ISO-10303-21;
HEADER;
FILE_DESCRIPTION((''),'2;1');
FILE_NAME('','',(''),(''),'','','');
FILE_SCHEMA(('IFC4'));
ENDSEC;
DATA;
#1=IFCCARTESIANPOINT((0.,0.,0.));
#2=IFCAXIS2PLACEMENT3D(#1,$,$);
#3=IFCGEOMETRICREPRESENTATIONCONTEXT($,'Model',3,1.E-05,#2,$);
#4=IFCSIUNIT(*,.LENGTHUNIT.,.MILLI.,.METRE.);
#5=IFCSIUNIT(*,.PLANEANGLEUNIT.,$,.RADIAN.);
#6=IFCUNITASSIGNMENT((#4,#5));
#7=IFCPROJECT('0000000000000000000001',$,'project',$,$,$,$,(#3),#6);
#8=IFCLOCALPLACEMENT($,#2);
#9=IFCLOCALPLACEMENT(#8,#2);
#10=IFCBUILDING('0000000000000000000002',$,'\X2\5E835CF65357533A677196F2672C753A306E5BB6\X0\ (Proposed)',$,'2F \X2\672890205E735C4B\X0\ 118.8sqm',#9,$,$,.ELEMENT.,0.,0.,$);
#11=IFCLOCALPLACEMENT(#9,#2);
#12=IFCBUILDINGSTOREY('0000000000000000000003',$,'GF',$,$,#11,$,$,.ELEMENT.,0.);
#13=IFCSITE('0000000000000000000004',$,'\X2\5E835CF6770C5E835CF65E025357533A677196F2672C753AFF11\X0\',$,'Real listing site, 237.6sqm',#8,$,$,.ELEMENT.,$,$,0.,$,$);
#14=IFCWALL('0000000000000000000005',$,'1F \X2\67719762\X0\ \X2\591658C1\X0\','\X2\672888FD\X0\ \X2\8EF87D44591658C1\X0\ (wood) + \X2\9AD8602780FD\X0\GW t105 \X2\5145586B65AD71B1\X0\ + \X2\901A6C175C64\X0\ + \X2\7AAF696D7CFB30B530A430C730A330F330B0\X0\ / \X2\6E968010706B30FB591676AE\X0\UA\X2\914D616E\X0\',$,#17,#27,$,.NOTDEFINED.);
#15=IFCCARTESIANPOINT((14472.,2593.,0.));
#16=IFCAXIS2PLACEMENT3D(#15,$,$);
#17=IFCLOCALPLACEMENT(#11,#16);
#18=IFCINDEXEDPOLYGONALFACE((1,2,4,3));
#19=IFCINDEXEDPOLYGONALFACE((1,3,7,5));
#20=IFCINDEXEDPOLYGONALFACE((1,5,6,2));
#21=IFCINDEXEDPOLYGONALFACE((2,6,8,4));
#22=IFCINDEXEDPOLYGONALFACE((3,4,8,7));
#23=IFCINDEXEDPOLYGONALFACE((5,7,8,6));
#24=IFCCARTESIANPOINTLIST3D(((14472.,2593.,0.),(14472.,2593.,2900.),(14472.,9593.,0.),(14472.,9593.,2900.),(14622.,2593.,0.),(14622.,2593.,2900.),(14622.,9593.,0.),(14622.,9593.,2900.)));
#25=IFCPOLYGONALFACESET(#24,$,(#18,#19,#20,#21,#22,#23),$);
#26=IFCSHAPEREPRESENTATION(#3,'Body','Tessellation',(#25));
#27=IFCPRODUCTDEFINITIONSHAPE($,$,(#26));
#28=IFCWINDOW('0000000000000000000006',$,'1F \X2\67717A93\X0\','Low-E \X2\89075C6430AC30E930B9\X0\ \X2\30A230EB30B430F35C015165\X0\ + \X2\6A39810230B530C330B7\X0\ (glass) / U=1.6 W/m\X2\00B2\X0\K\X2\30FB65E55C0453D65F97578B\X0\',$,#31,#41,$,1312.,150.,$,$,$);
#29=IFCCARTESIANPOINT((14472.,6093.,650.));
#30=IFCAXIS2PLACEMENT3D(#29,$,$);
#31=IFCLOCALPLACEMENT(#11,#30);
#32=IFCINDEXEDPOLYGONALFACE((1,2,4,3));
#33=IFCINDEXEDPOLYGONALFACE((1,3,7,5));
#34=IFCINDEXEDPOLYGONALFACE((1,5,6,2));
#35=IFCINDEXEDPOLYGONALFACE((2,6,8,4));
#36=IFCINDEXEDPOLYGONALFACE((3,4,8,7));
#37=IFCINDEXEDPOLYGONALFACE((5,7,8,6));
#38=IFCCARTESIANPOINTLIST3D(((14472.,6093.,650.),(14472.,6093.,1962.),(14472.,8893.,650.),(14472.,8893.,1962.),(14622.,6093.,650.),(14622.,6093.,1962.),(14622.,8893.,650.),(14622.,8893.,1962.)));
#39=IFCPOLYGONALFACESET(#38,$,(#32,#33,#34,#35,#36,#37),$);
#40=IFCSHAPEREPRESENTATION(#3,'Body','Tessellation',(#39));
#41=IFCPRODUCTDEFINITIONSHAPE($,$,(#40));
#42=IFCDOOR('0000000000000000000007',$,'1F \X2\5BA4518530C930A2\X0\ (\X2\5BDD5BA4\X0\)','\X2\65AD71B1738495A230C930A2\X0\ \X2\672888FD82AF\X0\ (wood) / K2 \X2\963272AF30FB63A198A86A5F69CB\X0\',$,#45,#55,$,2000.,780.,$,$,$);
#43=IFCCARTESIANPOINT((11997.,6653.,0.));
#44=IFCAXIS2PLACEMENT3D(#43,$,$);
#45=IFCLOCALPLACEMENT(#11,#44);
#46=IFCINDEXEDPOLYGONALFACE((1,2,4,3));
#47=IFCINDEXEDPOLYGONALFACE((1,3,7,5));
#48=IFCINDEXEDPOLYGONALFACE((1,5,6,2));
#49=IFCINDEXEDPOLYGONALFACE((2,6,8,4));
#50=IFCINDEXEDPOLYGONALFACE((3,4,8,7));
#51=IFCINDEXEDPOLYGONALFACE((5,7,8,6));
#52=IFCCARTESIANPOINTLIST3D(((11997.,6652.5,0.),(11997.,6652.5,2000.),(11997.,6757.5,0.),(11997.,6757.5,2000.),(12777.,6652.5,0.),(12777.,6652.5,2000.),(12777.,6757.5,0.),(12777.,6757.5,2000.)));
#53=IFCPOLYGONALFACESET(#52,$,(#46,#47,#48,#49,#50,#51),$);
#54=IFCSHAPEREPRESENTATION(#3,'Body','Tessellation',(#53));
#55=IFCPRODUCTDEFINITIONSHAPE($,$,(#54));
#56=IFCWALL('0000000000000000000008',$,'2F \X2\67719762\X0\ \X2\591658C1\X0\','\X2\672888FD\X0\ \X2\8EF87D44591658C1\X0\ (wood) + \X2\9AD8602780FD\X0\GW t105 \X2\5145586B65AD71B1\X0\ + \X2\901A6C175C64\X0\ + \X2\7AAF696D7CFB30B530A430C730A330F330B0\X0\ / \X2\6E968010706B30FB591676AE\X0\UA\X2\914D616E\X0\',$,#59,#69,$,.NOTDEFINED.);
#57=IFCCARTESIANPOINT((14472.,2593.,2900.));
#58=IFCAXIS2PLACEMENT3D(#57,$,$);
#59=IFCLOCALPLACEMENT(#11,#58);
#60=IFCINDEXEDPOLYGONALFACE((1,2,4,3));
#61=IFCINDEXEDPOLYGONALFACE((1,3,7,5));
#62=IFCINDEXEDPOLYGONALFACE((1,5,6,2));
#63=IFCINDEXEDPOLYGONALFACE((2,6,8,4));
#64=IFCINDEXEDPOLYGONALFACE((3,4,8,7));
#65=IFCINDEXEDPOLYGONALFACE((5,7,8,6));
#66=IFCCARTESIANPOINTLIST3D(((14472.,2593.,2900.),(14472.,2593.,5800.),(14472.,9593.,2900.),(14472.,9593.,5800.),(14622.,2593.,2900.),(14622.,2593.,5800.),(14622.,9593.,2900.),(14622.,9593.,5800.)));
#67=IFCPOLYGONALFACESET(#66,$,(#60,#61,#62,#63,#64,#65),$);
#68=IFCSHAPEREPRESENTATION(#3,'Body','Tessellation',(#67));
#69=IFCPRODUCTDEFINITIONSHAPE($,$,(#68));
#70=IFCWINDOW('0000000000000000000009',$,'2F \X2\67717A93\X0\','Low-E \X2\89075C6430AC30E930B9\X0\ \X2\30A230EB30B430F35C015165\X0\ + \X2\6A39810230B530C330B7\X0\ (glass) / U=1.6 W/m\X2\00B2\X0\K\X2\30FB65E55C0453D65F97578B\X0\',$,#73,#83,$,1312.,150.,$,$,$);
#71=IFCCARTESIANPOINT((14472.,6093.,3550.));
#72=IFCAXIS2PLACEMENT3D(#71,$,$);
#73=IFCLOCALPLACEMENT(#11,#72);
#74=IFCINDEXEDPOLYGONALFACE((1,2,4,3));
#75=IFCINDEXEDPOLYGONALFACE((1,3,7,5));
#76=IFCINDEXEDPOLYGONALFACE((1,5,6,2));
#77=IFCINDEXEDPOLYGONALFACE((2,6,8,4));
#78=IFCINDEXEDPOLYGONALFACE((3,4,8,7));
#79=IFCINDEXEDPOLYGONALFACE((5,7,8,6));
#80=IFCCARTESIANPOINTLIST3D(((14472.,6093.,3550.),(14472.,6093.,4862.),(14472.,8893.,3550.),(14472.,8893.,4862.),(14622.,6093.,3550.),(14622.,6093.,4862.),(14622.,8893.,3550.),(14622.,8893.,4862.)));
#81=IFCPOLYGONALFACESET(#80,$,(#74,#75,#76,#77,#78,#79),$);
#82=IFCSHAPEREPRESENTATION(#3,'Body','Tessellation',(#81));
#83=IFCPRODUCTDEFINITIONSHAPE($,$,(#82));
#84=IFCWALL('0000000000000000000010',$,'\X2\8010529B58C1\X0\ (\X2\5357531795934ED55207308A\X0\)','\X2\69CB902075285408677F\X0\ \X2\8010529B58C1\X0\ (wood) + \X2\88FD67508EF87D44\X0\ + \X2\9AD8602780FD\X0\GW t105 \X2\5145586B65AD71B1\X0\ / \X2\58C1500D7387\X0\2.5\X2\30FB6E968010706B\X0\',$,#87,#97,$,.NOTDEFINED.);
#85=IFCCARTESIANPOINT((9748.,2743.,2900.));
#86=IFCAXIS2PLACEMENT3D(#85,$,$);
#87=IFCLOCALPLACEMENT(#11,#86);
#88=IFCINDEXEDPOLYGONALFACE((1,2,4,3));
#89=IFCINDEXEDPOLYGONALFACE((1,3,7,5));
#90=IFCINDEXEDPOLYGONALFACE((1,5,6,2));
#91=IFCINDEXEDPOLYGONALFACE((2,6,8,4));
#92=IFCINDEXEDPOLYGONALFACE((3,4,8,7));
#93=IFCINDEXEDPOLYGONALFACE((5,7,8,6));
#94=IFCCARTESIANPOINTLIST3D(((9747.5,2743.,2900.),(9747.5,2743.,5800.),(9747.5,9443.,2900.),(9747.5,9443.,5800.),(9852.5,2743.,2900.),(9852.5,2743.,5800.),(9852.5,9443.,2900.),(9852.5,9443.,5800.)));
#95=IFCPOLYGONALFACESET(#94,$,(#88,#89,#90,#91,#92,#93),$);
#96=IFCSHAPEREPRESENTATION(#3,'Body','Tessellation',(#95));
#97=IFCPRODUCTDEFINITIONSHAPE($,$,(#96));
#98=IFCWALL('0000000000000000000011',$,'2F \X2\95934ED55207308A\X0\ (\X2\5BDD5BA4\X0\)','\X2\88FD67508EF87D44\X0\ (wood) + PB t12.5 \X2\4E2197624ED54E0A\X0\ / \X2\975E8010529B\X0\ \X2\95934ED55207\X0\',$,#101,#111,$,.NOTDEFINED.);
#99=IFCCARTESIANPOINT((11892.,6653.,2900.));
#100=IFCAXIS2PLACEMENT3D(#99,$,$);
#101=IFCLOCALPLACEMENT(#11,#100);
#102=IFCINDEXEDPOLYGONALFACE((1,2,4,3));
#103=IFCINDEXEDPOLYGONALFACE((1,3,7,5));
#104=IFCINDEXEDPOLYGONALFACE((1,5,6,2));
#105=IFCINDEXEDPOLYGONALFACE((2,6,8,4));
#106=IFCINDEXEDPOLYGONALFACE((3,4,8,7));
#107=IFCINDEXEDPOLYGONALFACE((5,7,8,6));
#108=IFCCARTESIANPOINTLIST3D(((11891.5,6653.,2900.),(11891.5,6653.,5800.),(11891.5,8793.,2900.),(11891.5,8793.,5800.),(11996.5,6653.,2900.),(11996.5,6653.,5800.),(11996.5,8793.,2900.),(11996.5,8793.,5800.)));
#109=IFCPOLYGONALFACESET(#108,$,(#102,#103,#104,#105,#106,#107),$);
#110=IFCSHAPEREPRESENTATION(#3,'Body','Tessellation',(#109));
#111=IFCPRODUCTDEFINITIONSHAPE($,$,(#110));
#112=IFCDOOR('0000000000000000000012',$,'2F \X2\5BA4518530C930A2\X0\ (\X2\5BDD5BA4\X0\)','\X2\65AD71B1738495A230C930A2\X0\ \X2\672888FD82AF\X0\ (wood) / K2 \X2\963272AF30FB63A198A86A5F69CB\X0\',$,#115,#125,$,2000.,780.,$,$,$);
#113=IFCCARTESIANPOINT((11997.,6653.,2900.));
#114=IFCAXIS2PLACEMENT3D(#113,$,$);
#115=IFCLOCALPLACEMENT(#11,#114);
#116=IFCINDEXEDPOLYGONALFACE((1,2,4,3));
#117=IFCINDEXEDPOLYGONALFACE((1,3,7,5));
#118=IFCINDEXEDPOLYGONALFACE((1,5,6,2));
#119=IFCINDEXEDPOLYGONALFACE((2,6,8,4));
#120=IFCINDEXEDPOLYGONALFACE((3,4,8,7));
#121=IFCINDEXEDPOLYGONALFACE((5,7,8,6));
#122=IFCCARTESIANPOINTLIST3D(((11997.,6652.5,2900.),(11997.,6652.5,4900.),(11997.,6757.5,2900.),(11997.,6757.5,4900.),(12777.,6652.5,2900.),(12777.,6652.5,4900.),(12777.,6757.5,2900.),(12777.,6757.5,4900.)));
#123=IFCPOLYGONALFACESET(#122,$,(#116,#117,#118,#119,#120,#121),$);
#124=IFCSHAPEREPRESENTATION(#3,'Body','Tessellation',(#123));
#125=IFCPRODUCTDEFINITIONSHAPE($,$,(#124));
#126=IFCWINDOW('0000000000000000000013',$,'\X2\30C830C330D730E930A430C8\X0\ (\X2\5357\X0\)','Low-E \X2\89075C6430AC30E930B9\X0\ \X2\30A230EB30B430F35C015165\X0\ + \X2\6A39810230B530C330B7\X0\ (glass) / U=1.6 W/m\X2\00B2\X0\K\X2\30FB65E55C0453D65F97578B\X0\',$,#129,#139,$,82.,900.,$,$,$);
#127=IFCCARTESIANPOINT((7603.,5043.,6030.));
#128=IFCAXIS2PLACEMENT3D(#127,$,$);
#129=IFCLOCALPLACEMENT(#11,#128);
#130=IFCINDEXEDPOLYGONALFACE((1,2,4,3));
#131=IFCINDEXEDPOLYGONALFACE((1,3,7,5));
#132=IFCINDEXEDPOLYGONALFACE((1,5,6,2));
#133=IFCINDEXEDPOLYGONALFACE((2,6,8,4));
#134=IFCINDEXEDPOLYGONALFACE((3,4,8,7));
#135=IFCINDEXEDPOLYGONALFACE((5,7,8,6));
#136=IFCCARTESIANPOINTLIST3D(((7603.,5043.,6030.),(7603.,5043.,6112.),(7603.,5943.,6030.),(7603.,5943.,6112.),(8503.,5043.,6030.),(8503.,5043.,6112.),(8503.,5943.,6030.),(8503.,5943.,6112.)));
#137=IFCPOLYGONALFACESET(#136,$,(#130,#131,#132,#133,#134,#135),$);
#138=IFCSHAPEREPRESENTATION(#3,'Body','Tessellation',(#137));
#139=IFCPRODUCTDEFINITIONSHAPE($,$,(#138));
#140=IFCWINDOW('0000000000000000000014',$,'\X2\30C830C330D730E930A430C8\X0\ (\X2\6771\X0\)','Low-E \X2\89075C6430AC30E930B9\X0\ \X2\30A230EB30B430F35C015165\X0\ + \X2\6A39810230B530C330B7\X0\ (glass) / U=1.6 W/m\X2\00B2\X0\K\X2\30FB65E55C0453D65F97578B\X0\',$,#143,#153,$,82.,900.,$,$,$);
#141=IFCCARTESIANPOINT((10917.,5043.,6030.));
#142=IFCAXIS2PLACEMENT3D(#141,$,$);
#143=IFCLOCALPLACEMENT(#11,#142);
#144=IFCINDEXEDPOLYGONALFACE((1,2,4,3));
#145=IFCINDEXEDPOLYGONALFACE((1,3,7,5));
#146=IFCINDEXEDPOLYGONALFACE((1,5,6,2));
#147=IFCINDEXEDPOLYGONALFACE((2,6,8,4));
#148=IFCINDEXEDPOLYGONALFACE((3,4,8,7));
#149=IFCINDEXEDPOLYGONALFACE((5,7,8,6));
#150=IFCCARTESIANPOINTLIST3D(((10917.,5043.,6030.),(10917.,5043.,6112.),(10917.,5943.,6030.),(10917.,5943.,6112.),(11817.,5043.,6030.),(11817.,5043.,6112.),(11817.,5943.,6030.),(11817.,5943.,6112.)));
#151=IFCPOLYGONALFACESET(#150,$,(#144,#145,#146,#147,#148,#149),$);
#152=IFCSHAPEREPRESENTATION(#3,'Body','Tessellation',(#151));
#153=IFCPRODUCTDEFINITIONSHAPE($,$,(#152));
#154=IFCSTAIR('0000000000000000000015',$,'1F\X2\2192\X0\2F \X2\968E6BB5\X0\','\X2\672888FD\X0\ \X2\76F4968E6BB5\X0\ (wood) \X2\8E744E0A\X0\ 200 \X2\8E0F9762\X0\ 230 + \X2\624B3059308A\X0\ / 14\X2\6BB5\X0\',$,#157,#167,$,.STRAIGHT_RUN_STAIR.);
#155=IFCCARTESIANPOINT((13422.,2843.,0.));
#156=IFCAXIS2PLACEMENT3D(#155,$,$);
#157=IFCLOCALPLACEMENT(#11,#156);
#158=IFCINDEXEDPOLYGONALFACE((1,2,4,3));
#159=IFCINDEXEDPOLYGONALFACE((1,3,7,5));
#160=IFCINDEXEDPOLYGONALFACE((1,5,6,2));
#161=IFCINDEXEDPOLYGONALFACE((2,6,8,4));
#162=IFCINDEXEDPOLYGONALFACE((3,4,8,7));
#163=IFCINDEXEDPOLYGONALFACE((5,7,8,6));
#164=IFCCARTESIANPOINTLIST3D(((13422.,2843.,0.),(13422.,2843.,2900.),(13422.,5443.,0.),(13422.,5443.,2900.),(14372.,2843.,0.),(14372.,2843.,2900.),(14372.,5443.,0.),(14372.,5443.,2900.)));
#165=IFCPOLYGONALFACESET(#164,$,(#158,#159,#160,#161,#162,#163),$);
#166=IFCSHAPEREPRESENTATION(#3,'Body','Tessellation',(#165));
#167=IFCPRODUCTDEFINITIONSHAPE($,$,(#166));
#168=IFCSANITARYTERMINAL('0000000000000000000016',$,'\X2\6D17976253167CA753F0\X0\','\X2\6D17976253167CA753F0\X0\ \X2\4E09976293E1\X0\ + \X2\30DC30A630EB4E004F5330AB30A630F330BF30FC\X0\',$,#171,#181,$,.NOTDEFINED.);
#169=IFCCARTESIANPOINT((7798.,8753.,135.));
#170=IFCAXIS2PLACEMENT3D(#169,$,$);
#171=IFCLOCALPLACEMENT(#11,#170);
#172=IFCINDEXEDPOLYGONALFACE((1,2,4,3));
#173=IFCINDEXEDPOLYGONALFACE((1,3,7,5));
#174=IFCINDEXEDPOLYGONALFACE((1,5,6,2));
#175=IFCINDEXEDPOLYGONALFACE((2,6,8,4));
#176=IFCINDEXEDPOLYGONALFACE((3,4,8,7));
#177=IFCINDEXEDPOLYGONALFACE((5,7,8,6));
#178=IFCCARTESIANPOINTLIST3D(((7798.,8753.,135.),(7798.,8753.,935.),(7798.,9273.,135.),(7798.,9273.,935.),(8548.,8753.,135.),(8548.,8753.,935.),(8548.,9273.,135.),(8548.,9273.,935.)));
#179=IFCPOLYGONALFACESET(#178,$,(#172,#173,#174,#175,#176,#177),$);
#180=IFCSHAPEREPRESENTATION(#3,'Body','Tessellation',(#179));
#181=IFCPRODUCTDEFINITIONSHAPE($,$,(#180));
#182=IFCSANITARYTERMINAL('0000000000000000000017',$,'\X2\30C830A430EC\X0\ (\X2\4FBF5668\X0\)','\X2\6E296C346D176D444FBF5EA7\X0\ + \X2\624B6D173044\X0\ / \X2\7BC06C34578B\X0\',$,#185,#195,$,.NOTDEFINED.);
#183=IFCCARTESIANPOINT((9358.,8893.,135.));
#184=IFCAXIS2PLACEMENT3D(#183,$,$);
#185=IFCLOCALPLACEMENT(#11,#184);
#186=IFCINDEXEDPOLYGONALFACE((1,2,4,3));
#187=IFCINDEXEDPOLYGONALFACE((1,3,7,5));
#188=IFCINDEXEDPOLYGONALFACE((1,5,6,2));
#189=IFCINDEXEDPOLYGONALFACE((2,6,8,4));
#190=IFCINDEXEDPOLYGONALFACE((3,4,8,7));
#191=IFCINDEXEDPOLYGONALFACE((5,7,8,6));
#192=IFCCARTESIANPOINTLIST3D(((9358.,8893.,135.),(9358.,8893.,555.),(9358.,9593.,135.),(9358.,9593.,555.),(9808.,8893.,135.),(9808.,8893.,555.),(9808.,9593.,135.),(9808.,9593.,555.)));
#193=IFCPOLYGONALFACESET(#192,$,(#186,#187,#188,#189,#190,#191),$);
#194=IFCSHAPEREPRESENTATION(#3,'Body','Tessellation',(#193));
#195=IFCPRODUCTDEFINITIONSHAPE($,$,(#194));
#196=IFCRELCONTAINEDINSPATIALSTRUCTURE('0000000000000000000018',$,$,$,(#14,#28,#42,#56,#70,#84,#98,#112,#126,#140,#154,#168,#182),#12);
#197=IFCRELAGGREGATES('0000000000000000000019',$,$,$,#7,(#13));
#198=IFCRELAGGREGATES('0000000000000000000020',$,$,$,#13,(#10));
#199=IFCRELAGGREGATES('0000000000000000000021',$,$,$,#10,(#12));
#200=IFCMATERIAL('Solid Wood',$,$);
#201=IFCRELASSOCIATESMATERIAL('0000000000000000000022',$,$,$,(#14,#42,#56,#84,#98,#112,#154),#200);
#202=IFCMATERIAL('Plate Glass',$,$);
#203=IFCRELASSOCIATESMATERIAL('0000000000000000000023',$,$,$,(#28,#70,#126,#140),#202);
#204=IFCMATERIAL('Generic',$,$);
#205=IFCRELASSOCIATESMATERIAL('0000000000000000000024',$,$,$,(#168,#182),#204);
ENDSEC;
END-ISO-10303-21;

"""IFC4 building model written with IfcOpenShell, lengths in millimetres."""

from ifc_helpers import new_model, si_unit, frame, frame_2d, origin, place, context, project, spatial, rectangle, extrude, material, element, fill, save


model = new_model("IFC4")

# Units and contexts
model_context = context("Model", 3, precision=1e-05, world=origin())
ifc_project = project(units=[si_unit("LENGTHUNIT", "METRE", prefix="MILLI"), si_unit("PLANEANGLEUNIT", "RADIAN")], contexts=[model_context])

# Site, building, storey
site_placement = place(None, origin())
site = spatial("IfcSite", under=ifc_project, at=site_placement, Name="広島県広島市南区東雲本町１", ObjectType="Real listing site, 237.6sqm", CompositionType="ELEMENT", RefElevation=0.0)
building_placement = place(site_placement, origin())
building = spatial("IfcBuilding", under=site, at=building_placement, Name="広島南区東雲本町の家 (Proposed)", ObjectType="2F 木造平屋 118.8sqm", CompositionType="ELEMENT", ElevationOfRefHeight=0.0, ElevationOfTerrain=0.0)
storey_placement = place(building_placement, origin())
storey = spatial("IfcBuildingStorey", under=building, at=storey_placement, Name="GF", CompositionType="ELEMENT", Elevation=0.0)

# Wall, opening, window
ifc_material_1 = material(Name="Solid Wood")
wall_1_placement = place(storey_placement, frame((14472.0, 2593.0, 0.0)))
wall_1 = element("IfcWall", 1, at=wall_1_placement, inside=storey, material=ifc_material_1, Name="1F 東面 外壁", Description="木製 軸組外壁 (wood) + 高性能GW t105 充填断熱 + 通気層 + 窯業系サイディング / 準耐火・外皮UA配慮", PredefinedType="NOTDEFINED", context=model_context, shape_type="SweptSolid", body=[
    extrude(rectangle(XDim=150.0, YDim=7000.0, at=frame_2d((75.0, 3500.0))), frame((14472.0, 2593.0, 0.0)), (0.0, 0.0, 1.0), 2900.0),
])
opening_1_placement = place(storey_placement, frame((14472.0, 6093.0, 650.0)))
opening_1 = element("IfcOpeningElement", 2, at=opening_1_placement, cuts=wall_1, PredefinedType="NOTDEFINED", context=model_context, shape_type="SweptSolid", body=[
    extrude(rectangle(XDim=150.0, YDim=2800.0, at=frame_2d((75.0, 1400.0))), frame((14472.0, 6093.0, 650.0)), (0.0, 0.0, 1.0), 1312.0),
])
ifc_material_2 = material(Name="Plate Glass")
window_1_placement = place(storey_placement, frame((14472.0, 6093.0, 650.0)))
window_1 = element("IfcWindow", 3, at=window_1_placement, inside=storey, material=ifc_material_2, Name="1F 東窓", Description="Low-E 複層ガラス アルゴン封入 + 樹脂サッシ (glass) / U=1.6 W/m²K・日射取得型", OverallHeight=1312.0, OverallWidth=150.0, context=model_context, shape_type="SweptSolid", body=[
    extrude(rectangle(XDim=150.0, YDim=2800.0, at=frame_2d((75.0, 1400.0))), frame((14472.0, 6093.0, 650.0)), (0.0, 0.0, 1.0), 1312.0),
])
fill(opening_1, window_1)

# Door
door_1_placement = place(storey_placement, frame((11997.0, 6653.0, 0.0)))
element("IfcDoor", 4, at=door_1_placement, inside=storey, material=ifc_material_1, Name="1F 室内ドア (寝室)", Description="断熱玄関ドア 木製芯 (wood) / K2 防犯・採風機構", OverallHeight=2000.0, OverallWidth=780.0, context=model_context, shape_type="SweptSolid", body=[
    extrude(rectangle(XDim=780.0, YDim=105.0, at=frame_2d((390.0, 52.0))), frame((11997.0, 6653.0, 0.0)), (0.0, 0.0, 1.0), 2000.0),
])

# Wall, opening, window
wall_2_placement = place(storey_placement, frame((14472.0, 2593.0, 2900.0)))
wall_2 = element("IfcWall", 5, at=wall_2_placement, inside=storey, material=ifc_material_1, Name="2F 東面 外壁", Description="木製 軸組外壁 (wood) + 高性能GW t105 充填断熱 + 通気層 + 窯業系サイディング / 準耐火・外皮UA配慮", PredefinedType="NOTDEFINED", context=model_context, shape_type="SweptSolid", body=[
    extrude(rectangle(XDim=150.0, YDim=7000.0, at=frame_2d((75.0, 3500.0))), frame((14472.0, 2593.0, 2900.0)), (0.0, 0.0, 1.0), 2900.0),
])
opening_2_placement = place(storey_placement, frame((14472.0, 6093.0, 3550.0)))
opening_2 = element("IfcOpeningElement", 6, at=opening_2_placement, cuts=wall_2, PredefinedType="NOTDEFINED", context=model_context, shape_type="SweptSolid", body=[
    extrude(rectangle(XDim=150.0, YDim=2800.0, at=frame_2d((75.0, 1400.0))), frame((14472.0, 6093.0, 3550.0)), (0.0, 0.0, 1.0), 1312.0),
])
window_2_placement = place(storey_placement, frame((14472.0, 6093.0, 3550.0)))
window_2 = element("IfcWindow", 7, at=window_2_placement, inside=storey, material=ifc_material_2, Name="2F 東窓", Description="Low-E 複層ガラス アルゴン封入 + 樹脂サッシ (glass) / U=1.6 W/m²K・日射取得型", OverallHeight=1312.0, OverallWidth=150.0, context=model_context, shape_type="SweptSolid", body=[
    extrude(rectangle(XDim=150.0, YDim=2800.0, at=frame_2d((75.0, 1400.0))), frame((14472.0, 6093.0, 3550.0)), (0.0, 0.0, 1.0), 1312.0),
])
fill(opening_2, window_2)

# Walls
wall_3_placement = place(storey_placement, frame((9748.0, 2743.0, 2900.0)))
element("IfcWall", 8, at=wall_3_placement, inside=storey, material=ifc_material_1, Name="耐力壁 (南北間仕切り)", Description="構造用合板 耐力壁 (wood) + 製材軸組 + 高性能GW t105 充填断熱 / 壁倍率2.5・準耐火", PredefinedType="NOTDEFINED", context=model_context, shape_type="SweptSolid", body=[
    extrude(rectangle(XDim=105.0, YDim=6700.0, at=frame_2d((52.0, 3350.0))), frame((9748.0, 2743.0, 2900.0)), (0.0, 0.0, 1.0), 2900.0),
])
wall_4_placement = place(storey_placement, frame((11892.0, 6653.0, 2900.0)))
element("IfcWall", 9, at=wall_4_placement, inside=storey, material=ifc_material_1, Name="2F 間仕切り (寝室)", Description="製材軸組 (wood) + PB t12.5 両面仕上 / 非耐力 間仕切", PredefinedType="NOTDEFINED", context=model_context, shape_type="SweptSolid", body=[
    extrude(rectangle(XDim=105.0, YDim=2140.0, at=frame_2d((52.0, 1070.0))), frame((11892.0, 6653.0, 2900.0)), (0.0, 0.0, 1.0), 2900.0),
])

# Door
door_2_placement = place(storey_placement, frame((11997.0, 6653.0, 2900.0)))
element("IfcDoor", 10, at=door_2_placement, inside=storey, material=ifc_material_1, Name="2F 室内ドア (寝室)", Description="断熱玄関ドア 木製芯 (wood) / K2 防犯・採風機構", OverallHeight=2000.0, OverallWidth=780.0, context=model_context, shape_type="SweptSolid", body=[
    extrude(rectangle(XDim=780.0, YDim=105.0, at=frame_2d((390.0, 52.0))), frame((11997.0, 6653.0, 2900.0)), (0.0, 0.0, 1.0), 2000.0),
])

# Windows
window_3_placement = place(storey_placement, frame((7603.0, 5043.0, 6030.0)))
element("IfcWindow", 11, at=window_3_placement, inside=storey, material=ifc_material_2, Name="トップライト (南)", Description="Low-E 複層ガラス アルゴン封入 + 樹脂サッシ (glass) / U=1.6 W/m²K・日射取得型", OverallHeight=82.0, OverallWidth=900.0, context=model_context, shape_type="SweptSolid", body=[
    extrude(rectangle(XDim=900.0, YDim=900.0, at=frame_2d((450.0, 450.0))), frame((7603.0, 5043.0, 6030.0)), (0.0, 0.0, 1.0), 82.0),
])
window_4_placement = place(storey_placement, frame((10917.0, 5043.0, 6030.0)))
element("IfcWindow", 12, at=window_4_placement, inside=storey, material=ifc_material_2, Name="トップライト (東)", Description="Low-E 複層ガラス アルゴン封入 + 樹脂サッシ (glass) / U=1.6 W/m²K・日射取得型", OverallHeight=82.0, OverallWidth=900.0, context=model_context, shape_type="SweptSolid", body=[
    extrude(rectangle(XDim=900.0, YDim=900.0, at=frame_2d((450.0, 450.0))), frame((10917.0, 5043.0, 6030.0)), (0.0, 0.0, 1.0), 82.0),
])

# Stair
stair_placement = place(storey_placement, frame((13422.0, 2843.0, 0.0)))
element("IfcStair", 13, at=stair_placement, inside=storey, material=ifc_material_1, Name="1F→2F 階段", Description="木製 直階段 (wood) 蹴上 200 踏面 230 + 手すり / 14段", PredefinedType="STRAIGHT_RUN_STAIR", context=model_context, shape_type="SweptSolid", body=[
    extrude(rectangle(XDim=950.0, YDim=2600.0, at=frame_2d((475.0, 1300.0))), frame((13422.0, 2843.0, 0.0)), (0.0, 0.0, 1.0), 2900.0),
])

# Sanitary terminals
ifc_material_3 = material(Name="Generic")
sanitary_terminal_1_placement = place(storey_placement, frame((7798.0, 8753.0, 135.0)))
element("IfcSanitaryTerminal", 14, at=sanitary_terminal_1_placement, inside=storey, material=ifc_material_3, Name="洗面化粧台", Description="洗面化粧台 三面鏡 + ボウル一体カウンター", PredefinedType="NOTDEFINED", context=model_context, shape_type="SweptSolid", body=[
    extrude(rectangle(XDim=750.0, YDim=520.0, at=frame_2d((375.0, 260.0))), frame((7798.0, 8753.0, 135.0)), (0.0, 0.0, 1.0), 800.0),
])
sanitary_terminal_2_placement = place(storey_placement, frame((9358.0, 8893.0, 135.0)))
element("IfcSanitaryTerminal", 15, at=sanitary_terminal_2_placement, inside=storey, material=ifc_material_3, Name="トイレ (便器)", Description="温水洗浄便座 + 手洗い / 節水型", PredefinedType="NOTDEFINED", context=model_context, shape_type="SweptSolid", body=[
    extrude(rectangle(XDim=450.0, YDim=700.0, at=frame_2d((225.0, 350.0))), frame((9358.0, 8893.0, 135.0)), (0.0, 0.0, 1.0), 420.0),
])

save(model, "model.ifc")
